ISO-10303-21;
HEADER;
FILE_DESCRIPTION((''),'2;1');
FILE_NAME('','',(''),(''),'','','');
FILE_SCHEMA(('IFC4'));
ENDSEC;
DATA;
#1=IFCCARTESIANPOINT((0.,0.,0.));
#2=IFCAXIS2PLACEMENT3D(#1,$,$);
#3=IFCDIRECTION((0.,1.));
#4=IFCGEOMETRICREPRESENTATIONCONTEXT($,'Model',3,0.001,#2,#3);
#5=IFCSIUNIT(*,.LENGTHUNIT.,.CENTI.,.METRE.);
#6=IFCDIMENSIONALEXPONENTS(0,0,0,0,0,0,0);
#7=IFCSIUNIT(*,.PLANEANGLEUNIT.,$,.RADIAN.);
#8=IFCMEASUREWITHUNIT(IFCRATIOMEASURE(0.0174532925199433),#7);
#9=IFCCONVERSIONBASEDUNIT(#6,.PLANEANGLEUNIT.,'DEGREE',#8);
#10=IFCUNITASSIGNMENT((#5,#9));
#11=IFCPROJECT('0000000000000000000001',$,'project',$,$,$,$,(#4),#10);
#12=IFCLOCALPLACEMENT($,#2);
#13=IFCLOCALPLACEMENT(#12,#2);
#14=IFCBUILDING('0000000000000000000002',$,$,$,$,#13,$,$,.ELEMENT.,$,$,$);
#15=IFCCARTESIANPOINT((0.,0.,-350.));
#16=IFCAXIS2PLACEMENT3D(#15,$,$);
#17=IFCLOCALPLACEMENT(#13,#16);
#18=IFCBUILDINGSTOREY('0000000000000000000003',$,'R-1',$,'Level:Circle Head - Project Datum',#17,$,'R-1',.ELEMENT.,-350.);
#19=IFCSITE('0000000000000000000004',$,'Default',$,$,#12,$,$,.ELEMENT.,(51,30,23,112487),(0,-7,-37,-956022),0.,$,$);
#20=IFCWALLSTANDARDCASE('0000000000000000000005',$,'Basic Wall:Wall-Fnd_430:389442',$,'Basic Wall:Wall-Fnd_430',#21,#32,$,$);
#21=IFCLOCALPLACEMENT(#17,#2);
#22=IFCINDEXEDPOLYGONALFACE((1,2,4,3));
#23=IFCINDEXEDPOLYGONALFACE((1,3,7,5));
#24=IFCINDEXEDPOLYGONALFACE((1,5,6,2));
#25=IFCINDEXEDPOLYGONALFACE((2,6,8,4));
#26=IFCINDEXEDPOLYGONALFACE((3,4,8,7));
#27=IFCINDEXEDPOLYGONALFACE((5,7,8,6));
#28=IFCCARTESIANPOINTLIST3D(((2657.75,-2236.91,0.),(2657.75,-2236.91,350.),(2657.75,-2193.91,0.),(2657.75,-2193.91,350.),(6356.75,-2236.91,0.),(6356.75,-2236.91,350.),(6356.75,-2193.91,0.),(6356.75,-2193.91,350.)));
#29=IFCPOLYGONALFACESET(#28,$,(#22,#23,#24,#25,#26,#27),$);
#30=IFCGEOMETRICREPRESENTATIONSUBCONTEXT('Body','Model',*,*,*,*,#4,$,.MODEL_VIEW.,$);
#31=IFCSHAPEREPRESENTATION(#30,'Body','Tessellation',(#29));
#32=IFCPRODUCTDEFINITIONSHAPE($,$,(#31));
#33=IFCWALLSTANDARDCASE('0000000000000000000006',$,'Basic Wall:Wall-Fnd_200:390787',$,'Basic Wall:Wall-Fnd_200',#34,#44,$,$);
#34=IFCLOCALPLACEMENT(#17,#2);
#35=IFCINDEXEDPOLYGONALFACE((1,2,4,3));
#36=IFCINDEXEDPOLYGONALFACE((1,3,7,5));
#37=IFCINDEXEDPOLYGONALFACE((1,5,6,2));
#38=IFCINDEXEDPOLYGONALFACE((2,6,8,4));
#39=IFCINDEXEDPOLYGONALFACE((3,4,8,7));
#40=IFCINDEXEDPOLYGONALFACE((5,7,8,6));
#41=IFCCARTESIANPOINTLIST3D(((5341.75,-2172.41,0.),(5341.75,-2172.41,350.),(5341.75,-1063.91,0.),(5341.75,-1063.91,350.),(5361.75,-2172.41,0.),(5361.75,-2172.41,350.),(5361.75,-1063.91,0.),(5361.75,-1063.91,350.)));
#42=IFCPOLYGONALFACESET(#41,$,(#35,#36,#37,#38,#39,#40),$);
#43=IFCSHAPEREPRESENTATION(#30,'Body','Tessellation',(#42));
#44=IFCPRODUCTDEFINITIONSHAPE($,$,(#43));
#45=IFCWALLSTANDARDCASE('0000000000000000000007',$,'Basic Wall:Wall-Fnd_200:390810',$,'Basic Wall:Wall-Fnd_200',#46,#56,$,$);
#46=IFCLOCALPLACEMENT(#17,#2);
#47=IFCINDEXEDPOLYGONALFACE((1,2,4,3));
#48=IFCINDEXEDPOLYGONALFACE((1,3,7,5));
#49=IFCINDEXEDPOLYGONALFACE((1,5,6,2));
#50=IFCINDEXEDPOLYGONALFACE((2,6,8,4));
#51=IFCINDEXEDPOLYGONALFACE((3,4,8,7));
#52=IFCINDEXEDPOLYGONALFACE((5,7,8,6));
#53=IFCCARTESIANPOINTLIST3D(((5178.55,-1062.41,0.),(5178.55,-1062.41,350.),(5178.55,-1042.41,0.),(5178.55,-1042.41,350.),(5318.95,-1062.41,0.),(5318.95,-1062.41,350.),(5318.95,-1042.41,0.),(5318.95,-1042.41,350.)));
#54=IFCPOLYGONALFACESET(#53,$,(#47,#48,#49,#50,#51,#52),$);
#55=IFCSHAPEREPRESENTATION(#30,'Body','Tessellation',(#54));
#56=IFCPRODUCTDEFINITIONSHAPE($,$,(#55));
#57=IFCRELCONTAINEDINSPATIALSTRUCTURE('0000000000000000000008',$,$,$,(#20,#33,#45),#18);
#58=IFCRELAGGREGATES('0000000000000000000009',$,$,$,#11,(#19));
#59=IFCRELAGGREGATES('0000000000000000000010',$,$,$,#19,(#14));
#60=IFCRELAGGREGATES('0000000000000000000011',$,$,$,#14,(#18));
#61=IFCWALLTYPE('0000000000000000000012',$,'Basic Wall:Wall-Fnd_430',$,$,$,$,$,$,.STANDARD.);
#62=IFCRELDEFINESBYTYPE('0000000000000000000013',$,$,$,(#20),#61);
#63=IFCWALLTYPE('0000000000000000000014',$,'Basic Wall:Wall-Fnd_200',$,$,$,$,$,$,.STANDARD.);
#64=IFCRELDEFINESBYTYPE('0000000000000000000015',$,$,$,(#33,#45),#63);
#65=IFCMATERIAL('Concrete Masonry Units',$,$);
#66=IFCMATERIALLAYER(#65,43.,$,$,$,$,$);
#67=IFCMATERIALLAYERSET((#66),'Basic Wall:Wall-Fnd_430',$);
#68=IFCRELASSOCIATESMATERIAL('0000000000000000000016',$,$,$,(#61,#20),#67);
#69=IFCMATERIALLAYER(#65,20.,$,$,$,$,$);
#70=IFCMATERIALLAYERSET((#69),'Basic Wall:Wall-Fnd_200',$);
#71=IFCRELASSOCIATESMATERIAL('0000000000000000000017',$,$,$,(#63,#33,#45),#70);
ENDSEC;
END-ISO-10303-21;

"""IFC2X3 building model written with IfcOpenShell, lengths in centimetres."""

from ifc_helpers import new_model, entity, si_unit, converted_unit, direction, frame, frame_2d, origin, place, context, subcontext, project, spatial, rectangle, extrude, material, layer, layer_set, layer_usage, type_object, element, save


model = new_model("IFC2X3")

# Units and contexts
model_context = context("Model", 3, precision=0.001, world=origin(), true_north=direction((0.0, 1.0)))
body_context = subcontext(model_context, "Body", "Model", "MODEL_VIEW")
ifc_project = project(units=[si_unit("LENGTHUNIT", "METRE", prefix="CENTI"), converted_unit("PLANEANGLEUNIT", "DEGREE", entity("IfcRatioMeasure", 0.0174532925199433), si_unit("PLANEANGLEUNIT", "RADIAN"), dimensions=[0, 0, 0, 0, 0, 0, 0])], contexts=[model_context])

# Site, building, storey
site_placement = place(None, origin())
site = spatial("IfcSite", under=ifc_project, at=site_placement, Name="Default", CompositionType="ELEMENT", RefLatitude=(51, 30, 23, 112487), RefLongitude=(0, -7, -37, -956022), RefElevation=0.0)
building_placement = place(site_placement, origin())
building = spatial("IfcBuilding", under=site, at=building_placement, CompositionType="ELEMENT")
storey_placement = place(building_placement, frame((0.0, 0.0, -350.0)))
storey = spatial("IfcBuildingStorey", under=building, at=storey_placement, Name="R-1", ObjectType="Level:Circle Head - Project Datum", LongName="R-1", CompositionType="ELEMENT", Elevation=-350.0)

# Walls
ifc_material_1 = material(Name="Concrete Masonry Units")
ifc_layer_1 = layer(ifc_material_1, 43.0)
ifc_layer_set_1 = layer_set([ifc_layer_1], Name="Basic Wall:Wall-Fnd_430")
ifc_layer_usage_1 = layer_usage(ifc_layer_set_1, "AXIS2", "POSITIVE", -21.5)
wall_type_1 = type_object("IfcWallType", Name="Basic Wall:Wall-Fnd_430", PredefinedType="STANDARD", material=ifc_layer_set_1)
wall_1_placement = place(storey_placement, frame((6356.75, -2215.41, 0.0), z_axis=(0.0, 0.0, 1.0), x_axis=(-1.0, 0.0, 0.0)))
element("IfcWallStandardCase", 1, at=wall_1_placement, inside=storey, type_object=wall_type_1, material=ifc_layer_usage_1, Name="Basic Wall:Wall-Fnd_430:389442", ObjectType="Basic Wall:Wall-Fnd_430", context=body_context, shape_type="SweptSolid", body=[
    extrude(rectangle(XDim=3699.0, YDim=43.0, at=frame_2d((1849.5, 0.0), x_axis=(-1.0, 0.0))), origin(), (0.0, 0.0, 1.0), 350.0),
])
ifc_layer_2 = layer(ifc_material_1, 20.0)
ifc_layer_set_2 = layer_set([ifc_layer_2], Name="Basic Wall:Wall-Fnd_200")
ifc_layer_usage_2 = layer_usage(ifc_layer_set_2, "AXIS2", "POSITIVE", -10.0)
wall_type_2 = type_object("IfcWallType", Name="Basic Wall:Wall-Fnd_200", PredefinedType="STANDARD", material=ifc_layer_set_2)
wall_2_placement = place(storey_placement, frame((5351.75, -2172.41, 0.0), z_axis=(0.0, 0.0, 1.0), x_axis=(0.0, 1.0, 0.0)))
element("IfcWallStandardCase", 2, at=wall_2_placement, inside=storey, type_object=wall_type_2, material=ifc_layer_usage_2, Name="Basic Wall:Wall-Fnd_200:390787", ObjectType="Basic Wall:Wall-Fnd_200", context=body_context, shape_type="SweptSolid", body=[
    extrude(rectangle(XDim=1108.5, YDim=20.0, at=frame_2d((554.25, 0.0), x_axis=(-1.0, 0.0))), origin(), (0.0, 0.0, 1.0), 350.0),
])
ifc_layer_usage_3 = layer_usage(ifc_layer_set_2, "AXIS2", "POSITIVE", -10.0)
wall_3_placement = place(storey_placement, frame((5318.95, -1052.41, 0.0), z_axis=(0.0, 0.0, 1.0), x_axis=(-1.0, 0.0, 0.0)))
element("IfcWallStandardCase", 3, at=wall_3_placement, inside=storey, type_object=wall_type_2, material=ifc_layer_usage_3, Name="Basic Wall:Wall-Fnd_200:390810", ObjectType="Basic Wall:Wall-Fnd_200", context=body_context, shape_type="SweptSolid", body=[
    extrude(rectangle(XDim=140.4, YDim=20.0, at=frame_2d((70.2, 0.0), x_axis=(-1.0, 0.0))), origin(), (0.0, 0.0, 1.0), 350.0),
])

save(model, "model.ifc")
